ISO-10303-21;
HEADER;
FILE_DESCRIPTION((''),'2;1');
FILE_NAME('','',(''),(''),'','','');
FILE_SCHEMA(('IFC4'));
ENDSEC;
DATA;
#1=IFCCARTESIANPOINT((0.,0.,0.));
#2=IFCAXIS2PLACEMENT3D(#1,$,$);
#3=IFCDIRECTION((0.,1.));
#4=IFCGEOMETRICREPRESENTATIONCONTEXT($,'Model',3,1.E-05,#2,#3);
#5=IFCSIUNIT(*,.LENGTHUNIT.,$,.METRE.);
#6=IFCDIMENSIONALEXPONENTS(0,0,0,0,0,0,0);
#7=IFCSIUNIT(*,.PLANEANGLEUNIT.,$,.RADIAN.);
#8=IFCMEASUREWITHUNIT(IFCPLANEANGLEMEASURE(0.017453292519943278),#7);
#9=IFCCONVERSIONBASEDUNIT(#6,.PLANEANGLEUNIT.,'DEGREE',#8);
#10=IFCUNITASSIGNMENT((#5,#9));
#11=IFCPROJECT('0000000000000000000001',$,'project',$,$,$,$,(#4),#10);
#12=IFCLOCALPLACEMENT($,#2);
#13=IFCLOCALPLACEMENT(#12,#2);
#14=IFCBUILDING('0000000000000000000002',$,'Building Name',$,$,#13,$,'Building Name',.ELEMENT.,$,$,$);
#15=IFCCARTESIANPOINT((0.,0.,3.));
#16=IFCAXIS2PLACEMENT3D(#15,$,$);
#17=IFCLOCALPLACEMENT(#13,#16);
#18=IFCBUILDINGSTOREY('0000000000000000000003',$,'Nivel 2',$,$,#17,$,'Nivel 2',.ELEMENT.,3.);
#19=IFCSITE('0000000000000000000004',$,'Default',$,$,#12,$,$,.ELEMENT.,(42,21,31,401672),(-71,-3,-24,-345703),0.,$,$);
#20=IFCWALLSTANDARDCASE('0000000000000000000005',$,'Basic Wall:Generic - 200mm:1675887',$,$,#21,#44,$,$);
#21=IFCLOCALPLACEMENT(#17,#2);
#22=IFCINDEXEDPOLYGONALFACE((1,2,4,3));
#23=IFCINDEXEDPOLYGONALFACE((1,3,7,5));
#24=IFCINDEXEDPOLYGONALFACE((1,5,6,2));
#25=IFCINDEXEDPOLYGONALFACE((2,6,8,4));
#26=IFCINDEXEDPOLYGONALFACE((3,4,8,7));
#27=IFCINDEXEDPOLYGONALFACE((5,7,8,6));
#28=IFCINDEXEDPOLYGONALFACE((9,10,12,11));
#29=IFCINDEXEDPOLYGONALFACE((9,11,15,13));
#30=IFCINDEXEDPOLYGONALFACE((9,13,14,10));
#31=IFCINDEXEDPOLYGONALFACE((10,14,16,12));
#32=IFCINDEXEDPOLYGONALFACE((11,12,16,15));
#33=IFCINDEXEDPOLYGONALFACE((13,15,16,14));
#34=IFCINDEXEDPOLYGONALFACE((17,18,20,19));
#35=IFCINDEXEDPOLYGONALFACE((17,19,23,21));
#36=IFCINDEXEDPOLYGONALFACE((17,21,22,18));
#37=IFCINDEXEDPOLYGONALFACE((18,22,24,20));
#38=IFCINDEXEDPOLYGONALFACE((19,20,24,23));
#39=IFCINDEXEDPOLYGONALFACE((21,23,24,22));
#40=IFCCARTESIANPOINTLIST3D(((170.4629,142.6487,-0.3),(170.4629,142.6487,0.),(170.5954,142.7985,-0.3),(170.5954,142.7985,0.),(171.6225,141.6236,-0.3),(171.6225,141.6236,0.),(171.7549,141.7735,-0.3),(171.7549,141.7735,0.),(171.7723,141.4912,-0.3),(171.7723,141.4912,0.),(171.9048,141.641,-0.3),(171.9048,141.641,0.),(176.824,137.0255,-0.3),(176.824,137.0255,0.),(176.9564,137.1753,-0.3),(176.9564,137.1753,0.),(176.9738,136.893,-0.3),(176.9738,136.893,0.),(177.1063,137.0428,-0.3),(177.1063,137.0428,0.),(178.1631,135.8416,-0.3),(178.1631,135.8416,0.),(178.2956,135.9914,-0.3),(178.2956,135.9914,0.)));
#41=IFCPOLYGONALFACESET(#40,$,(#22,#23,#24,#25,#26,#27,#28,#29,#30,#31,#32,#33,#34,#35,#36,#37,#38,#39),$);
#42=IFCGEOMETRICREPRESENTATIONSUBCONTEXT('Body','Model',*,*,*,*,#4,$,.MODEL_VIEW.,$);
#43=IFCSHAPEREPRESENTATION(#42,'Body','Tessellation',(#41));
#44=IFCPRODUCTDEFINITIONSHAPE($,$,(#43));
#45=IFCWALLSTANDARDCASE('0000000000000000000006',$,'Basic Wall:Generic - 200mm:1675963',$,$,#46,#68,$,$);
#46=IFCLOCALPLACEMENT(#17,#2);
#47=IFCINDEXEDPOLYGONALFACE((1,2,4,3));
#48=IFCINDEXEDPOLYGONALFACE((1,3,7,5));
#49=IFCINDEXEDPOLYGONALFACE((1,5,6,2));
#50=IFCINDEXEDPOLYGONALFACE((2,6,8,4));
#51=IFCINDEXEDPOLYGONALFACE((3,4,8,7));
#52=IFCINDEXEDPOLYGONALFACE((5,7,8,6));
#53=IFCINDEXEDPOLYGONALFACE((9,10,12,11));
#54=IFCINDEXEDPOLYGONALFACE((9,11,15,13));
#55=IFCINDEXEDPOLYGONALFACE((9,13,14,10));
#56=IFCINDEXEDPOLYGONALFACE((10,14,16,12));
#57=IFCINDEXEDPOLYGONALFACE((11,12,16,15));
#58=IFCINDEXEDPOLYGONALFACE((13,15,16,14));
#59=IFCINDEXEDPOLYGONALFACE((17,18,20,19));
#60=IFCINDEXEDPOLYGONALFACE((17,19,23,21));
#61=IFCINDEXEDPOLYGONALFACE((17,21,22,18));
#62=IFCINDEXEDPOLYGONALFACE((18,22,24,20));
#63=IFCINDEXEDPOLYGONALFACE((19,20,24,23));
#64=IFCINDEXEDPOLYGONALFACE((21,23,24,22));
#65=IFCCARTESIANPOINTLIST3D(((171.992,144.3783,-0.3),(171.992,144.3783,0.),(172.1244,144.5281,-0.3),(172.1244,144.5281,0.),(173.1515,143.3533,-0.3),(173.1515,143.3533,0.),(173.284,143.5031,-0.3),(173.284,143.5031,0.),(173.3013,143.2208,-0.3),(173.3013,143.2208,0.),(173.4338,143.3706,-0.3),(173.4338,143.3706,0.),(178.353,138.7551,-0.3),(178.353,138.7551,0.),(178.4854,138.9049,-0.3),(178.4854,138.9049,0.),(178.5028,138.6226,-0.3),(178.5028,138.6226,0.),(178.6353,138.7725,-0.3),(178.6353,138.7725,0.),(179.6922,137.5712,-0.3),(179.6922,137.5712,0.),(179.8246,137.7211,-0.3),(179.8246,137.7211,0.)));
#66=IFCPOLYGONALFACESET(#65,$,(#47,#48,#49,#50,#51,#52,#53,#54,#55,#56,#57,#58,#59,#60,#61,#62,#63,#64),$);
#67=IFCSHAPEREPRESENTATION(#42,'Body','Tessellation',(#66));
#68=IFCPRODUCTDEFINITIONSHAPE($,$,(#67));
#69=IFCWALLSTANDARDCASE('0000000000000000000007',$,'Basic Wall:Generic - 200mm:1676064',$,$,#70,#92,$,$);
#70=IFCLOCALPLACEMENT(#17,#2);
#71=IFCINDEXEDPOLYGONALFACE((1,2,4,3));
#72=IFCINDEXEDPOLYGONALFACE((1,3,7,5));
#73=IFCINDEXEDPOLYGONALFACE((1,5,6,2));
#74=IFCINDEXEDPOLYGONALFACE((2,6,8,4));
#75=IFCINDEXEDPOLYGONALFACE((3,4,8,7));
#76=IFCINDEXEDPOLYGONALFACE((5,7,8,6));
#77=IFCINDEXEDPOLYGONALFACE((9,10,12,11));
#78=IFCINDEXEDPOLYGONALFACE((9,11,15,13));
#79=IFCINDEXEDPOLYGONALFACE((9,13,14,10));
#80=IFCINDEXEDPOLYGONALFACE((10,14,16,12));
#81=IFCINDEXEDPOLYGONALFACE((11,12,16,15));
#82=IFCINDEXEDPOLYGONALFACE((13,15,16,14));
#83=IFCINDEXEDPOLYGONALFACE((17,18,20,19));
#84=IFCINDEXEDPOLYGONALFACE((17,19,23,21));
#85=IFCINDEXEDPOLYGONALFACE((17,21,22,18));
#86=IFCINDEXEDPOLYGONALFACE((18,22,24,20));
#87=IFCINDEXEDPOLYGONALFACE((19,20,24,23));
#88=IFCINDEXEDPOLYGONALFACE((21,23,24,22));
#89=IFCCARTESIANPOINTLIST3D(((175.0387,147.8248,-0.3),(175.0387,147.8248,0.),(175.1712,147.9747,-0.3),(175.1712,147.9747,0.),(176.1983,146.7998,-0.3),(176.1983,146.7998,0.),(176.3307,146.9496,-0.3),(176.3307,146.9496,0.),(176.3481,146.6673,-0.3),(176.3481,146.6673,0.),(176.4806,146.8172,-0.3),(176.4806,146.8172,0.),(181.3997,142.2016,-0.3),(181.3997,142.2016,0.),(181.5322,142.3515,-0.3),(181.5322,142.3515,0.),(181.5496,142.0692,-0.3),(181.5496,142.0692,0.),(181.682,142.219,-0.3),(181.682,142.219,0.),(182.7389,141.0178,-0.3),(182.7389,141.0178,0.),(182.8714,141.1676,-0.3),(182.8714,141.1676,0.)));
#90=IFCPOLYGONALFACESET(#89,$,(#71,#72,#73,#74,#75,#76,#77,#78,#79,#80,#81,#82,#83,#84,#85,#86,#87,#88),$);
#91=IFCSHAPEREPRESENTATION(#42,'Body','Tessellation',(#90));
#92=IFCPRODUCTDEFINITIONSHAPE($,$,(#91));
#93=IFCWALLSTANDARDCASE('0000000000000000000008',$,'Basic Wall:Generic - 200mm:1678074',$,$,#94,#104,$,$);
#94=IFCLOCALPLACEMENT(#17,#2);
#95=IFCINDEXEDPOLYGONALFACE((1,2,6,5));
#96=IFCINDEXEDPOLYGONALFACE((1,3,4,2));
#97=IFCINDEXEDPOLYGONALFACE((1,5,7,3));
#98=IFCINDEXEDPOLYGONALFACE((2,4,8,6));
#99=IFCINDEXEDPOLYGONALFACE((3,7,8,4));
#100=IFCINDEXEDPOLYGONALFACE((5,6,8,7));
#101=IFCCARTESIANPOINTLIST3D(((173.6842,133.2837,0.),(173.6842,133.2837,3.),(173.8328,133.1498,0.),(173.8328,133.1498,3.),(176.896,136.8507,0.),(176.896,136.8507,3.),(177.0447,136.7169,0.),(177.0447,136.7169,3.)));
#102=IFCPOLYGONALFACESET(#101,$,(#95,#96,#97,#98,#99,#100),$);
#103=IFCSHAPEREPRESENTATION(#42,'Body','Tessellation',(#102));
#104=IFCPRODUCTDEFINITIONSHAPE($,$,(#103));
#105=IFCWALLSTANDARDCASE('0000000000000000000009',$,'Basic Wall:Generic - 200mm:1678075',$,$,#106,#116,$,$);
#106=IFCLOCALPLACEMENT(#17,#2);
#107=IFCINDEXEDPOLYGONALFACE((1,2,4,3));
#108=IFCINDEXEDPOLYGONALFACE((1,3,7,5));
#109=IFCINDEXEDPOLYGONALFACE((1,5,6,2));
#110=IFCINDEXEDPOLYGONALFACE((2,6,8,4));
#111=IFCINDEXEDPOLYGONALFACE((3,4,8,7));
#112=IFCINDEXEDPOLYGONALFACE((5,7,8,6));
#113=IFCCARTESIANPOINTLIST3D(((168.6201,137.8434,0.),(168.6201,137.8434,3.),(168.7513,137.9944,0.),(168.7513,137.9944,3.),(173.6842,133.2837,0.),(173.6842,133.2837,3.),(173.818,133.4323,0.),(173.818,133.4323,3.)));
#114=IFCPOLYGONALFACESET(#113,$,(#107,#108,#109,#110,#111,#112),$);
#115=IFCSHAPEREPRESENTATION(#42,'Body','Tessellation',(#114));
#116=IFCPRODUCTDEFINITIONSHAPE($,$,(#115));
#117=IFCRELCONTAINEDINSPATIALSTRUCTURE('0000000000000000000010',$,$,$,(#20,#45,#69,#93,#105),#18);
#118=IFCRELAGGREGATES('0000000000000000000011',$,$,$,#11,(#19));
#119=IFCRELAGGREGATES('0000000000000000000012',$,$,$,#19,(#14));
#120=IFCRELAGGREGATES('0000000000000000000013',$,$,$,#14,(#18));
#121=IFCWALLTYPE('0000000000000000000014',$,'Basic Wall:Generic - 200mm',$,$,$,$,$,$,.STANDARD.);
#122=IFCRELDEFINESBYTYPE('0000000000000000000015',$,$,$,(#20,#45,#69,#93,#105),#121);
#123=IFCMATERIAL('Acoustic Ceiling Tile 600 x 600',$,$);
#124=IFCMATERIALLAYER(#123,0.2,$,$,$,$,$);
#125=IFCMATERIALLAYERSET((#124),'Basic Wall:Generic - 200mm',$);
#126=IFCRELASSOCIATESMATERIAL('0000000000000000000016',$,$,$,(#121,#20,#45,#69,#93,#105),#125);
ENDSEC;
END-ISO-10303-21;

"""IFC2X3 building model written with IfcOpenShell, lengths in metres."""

from ifc_helpers import new_model, entity, si_unit, converted_unit, direction, frame, frame_2d, origin, origin_2d_with_axis, place, context, subcontext, project, spatial, polyline, rectangle, outline, extrude, material, layer, layer_set, layer_usage, type_object, element, save


model = new_model("IFC2X3")

# Units and contexts
model_context = context("Model", 3, precision=1e-05, world=origin(), true_north=direction((0.0, 1.0)))
body_context = subcontext(model_context, "Body", "Model", "MODEL_VIEW")
ifc_project = project(units=[si_unit("LENGTHUNIT", "METRE"), converted_unit("PLANEANGLEUNIT", "DEGREE", entity("IfcPlaneAngleMeasure", 0.017453292519943278), si_unit("PLANEANGLEUNIT", "RADIAN"), dimensions=[0, 0, 0, 0, 0, 0, 0])], contexts=[model_context])

# Site, building, storey
site_placement = place(None, origin())
site = spatial("IfcSite", under=ifc_project, at=site_placement, Name="Default", CompositionType="ELEMENT", RefLatitude=(42, 21, 31, 401672), RefLongitude=(-71, -3, -24, -345703), RefElevation=0.0)
building_placement = place(site_placement, origin())
building = spatial("IfcBuilding", under=site, at=building_placement, Name="Building Name", LongName="Building Name", CompositionType="ELEMENT")
storey_placement = place(building_placement, frame((0.0, 0.0, 3.0)))
storey = spatial("IfcBuildingStorey", under=building, at=storey_placement, Name="Nivel 2", LongName="Nivel 2", CompositionType="ELEMENT", Elevation=3.0)

# Shared definitions
ifc_material_1 = material(Name="Acoustic Ceiling Tile 600 x 600")
ifc_layer_1 = layer(ifc_material_1, 0.2)
ifc_layer_set_1 = layer_set([ifc_layer_1], Name="Basic Wall:Generic - 200mm")
wall_type_1 = type_object("IfcWallType", Name="Basic Wall:Generic - 200mm", PredefinedType="STANDARD", material=ifc_layer_set_1)

# Walls, openings
ifc_layer_usage_1 = layer_usage(ifc_layer_set_1, "AXIS2", "NEGATIVE", 0.1)
wall_1_placement = place(storey_placement, frame((178.2294, 135.9165, -0.3), z_axis=(0.0, 0.0, 1.0), x_axis=(-0.749221, 0.66232, 0.0)))
wall_1 = element("IfcWallStandardCase", 1, at=wall_1_placement, inside=storey, type_object=wall_type_1, material=ifc_layer_usage_1, Name="Basic Wall:Generic - 200mm:1675887", context=body_context, shape_type="SweptSolid", body=[
    extrude(rectangle(XDim=10.2776, YDim=0.2, at=frame_2d((5.1388, 0.0), x_axis=(-1.0, 0.0))), origin(), (0.0, 0.0, 1.0), 0.3),
])
opening_1_placement = place(storey_placement, frame((178.2294, 135.9165, -0.3), z_axis=(0.0, 0.0, 1.0), x_axis=(-0.749221, 0.66232, 0.0)))
element("IfcOpeningElement", 2, at=opening_1_placement, cuts=wall_1, ObjectType="Opening", context=body_context, shape_type="SweptSolid", body=[
    extrude(rectangle(XDim=0.3, YDim=0.2, at=origin_2d_with_axis()), frame((1.7874, 0.0, 0.15), z_axis=(-1.0, 0.0, 0.0), x_axis=(0.0, 0.0, 1.0)), (0.0, 0.0, 1.0), 0.2),
])
opening_2_placement = place(storey_placement, frame((178.2294, 135.9165, -0.3), z_axis=(0.0, 0.0, 1.0), x_axis=(-0.749221, 0.66232, 0.0)))
element("IfcOpeningElement", 3, at=opening_2_placement, cuts=wall_1, ObjectType="Opening", context=body_context, shape_type="SweptSolid", body=[
    extrude(rectangle(XDim=0.3, YDim=0.2, at=frame_2d((0.0, 0.0), x_axis=(1.0, 0.0))), frame((8.53, 0.0, 0.15), z_axis=(1.0, 0.0, 0.0), x_axis=(0.0, 0.0, -1.0)), (0.0, 0.0, 1.0), 0.2),
])
ifc_layer_usage_2 = layer_usage(ifc_layer_set_1, "AXIS2", "NEGATIVE", 0.1)
wall_2_placement = place(storey_placement, frame((179.7584, 137.6462, -0.3), z_axis=(0.0, 0.0, 1.0), x_axis=(-0.749221, 0.66232, 0.0)))
wall_2 = element("IfcWallStandardCase", 4, at=wall_2_placement, inside=storey, type_object=wall_type_1, material=ifc_layer_usage_2, Name="Basic Wall:Generic - 200mm:1675963", context=body_context, shape_type="SweptSolid", body=[
    extrude(rectangle(XDim=10.2776, YDim=0.2, at=frame_2d((5.1388, 0.0), x_axis=(-1.0, 0.0))), origin(), (0.0, 0.0, 1.0), 0.3),
])
opening_3_placement = place(storey_placement, frame((179.7584, 137.6462, -0.3), z_axis=(0.0, 0.0, 1.0), x_axis=(-0.749221, 0.66232, 0.0)))
element("IfcOpeningElement", 5, at=opening_3_placement, cuts=wall_2, ObjectType="Opening", context=body_context, shape_type="SweptSolid", body=[
    extrude(rectangle(XDim=0.3, YDim=0.2, at=frame_2d((0.0, 0.0), x_axis=(1.0, 0.0))), frame((1.5874, 0.0, 0.15), z_axis=(1.0, 0.0, 0.0), x_axis=(0.0, 0.0, -1.0)), (0.0, 0.0, 1.0), 0.2),
])
opening_4_placement = place(storey_placement, frame((179.7584, 137.6462, -0.3), z_axis=(0.0, 0.0, 1.0), x_axis=(-0.749221, 0.66232, 0.0)))
element("IfcOpeningElement", 6, at=opening_4_placement, cuts=wall_2, ObjectType="Opening", context=body_context, shape_type="SweptSolid", body=[
    extrude(rectangle(XDim=0.3, YDim=0.2, at=frame_2d((0.0, 0.0), x_axis=(1.0, 0.0))), frame((8.53, 0.0, 0.15), z_axis=(1.0, 0.0, 0.0), x_axis=(0.0, 0.0, -1.0)), (0.0, 0.0, 1.0), 0.2),
])
ifc_layer_usage_3 = layer_usage(ifc_layer_set_1, "AXIS2", "NEGATIVE", 0.1)
wall_3_placement = place(storey_placement, frame((182.8052, 141.0927, -0.3), z_axis=(0.0, 0.0, 1.0), x_axis=(-0.749221, 0.66232, 0.0)))
wall_3 = element("IfcWallStandardCase", 7, at=wall_3_placement, inside=storey, type_object=wall_type_1, material=ifc_layer_usage_3, Name="Basic Wall:Generic - 200mm:1676064", context=body_context, shape_type="SweptSolid", body=[
    extrude(rectangle(XDim=10.2776, YDim=0.2, at=frame_2d((5.1388, 0.0), x_axis=(-1.0, 0.0))), origin(), (0.0, 0.0, 1.0), 0.3),
])
opening_5_placement = place(storey_placement, frame((182.8052, 141.0927, -0.3), z_axis=(0.0, 0.0, 1.0), x_axis=(-0.749221, 0.66232, 0.0)))
element("IfcOpeningElement", 8, at=opening_5_placement, cuts=wall_3, ObjectType="Opening", context=body_context, shape_type="SweptSolid", body=[
    extrude(rectangle(XDim=0.3, YDim=0.2, at=frame_2d((0.0, 0.0), x_axis=(1.0, 0.0))), frame((1.7874, 0.0, 0.15), z_axis=(-1.0, 0.0, 0.0), x_axis=(0.0, 0.0, 1.0)), (0.0, 0.0, 1.0), 0.2),
])
opening_6_placement = place(storey_placement, frame((182.8052, 141.0927, -0.3), z_axis=(0.0, 0.0, 1.0), x_axis=(-0.749221, 0.66232, 0.0)))
element("IfcOpeningElement", 9, at=opening_6_placement, cuts=wall_3, ObjectType="Opening", context=body_context, shape_type="SweptSolid", body=[
    extrude(rectangle(XDim=0.3, YDim=0.2, at=frame_2d((0.0, 0.0), x_axis=(1.0, 0.0))), frame((8.53, 0.0, 0.15), z_axis=(1.0, 0.0, 0.0), x_axis=(0.0, 0.0, -1.0)), (0.0, 0.0, 1.0), 0.2),
])

# Walls
ifc_layer_usage_4 = layer_usage(ifc_layer_set_1, "AXIS2", "NEGATIVE", 0.1)
wall_4_placement = place(storey_placement, frame((176.9703, 136.7838, 0.0), z_axis=(0.0, 0.0, 1.0), x_axis=(-0.669131, -0.743145, 0.0)))
element("IfcWallStandardCase", 10, at=wall_4_placement, inside=storey, type_object=wall_type_1, material=ifc_layer_usage_4, Name="Basic Wall:Generic - 200mm:1678074", context=body_context, shape_type="SweptSolid", body=[
    extrude(rectangle(XDim=4.8, YDim=0.2, at=frame_2d((2.4, 0.0), x_axis=(-1.0, 0.0))), origin(), (0.0, 0.0, 1.0), 3.0),
])
ifc_layer_usage_5 = layer_usage(ifc_layer_set_1, "AXIS2", "NEGATIVE", 0.1)
wall_5_placement = place(storey_placement, frame((173.7511, 133.358, 0.0), z_axis=(0.0, 0.0, 1.0), x_axis=(-0.743145, 0.669131, 0.0)))
element("IfcWallStandardCase", 11, at=wall_5_placement, inside=storey, type_object=wall_type_1, material=ifc_layer_usage_5, Name="Basic Wall:Generic - 200mm:1678075", context=body_context, shape_type="SweptSolid", body=[
    extrude(outline(polyline([(6.8179, -0.1), (6.8145, 0.1), (0.0, 0.1), (0.0, -0.1), (6.8179, -0.1)])), origin(), (0.0, 0.0, 1.0), 3.0),
])

save(model, "model.ifc")
